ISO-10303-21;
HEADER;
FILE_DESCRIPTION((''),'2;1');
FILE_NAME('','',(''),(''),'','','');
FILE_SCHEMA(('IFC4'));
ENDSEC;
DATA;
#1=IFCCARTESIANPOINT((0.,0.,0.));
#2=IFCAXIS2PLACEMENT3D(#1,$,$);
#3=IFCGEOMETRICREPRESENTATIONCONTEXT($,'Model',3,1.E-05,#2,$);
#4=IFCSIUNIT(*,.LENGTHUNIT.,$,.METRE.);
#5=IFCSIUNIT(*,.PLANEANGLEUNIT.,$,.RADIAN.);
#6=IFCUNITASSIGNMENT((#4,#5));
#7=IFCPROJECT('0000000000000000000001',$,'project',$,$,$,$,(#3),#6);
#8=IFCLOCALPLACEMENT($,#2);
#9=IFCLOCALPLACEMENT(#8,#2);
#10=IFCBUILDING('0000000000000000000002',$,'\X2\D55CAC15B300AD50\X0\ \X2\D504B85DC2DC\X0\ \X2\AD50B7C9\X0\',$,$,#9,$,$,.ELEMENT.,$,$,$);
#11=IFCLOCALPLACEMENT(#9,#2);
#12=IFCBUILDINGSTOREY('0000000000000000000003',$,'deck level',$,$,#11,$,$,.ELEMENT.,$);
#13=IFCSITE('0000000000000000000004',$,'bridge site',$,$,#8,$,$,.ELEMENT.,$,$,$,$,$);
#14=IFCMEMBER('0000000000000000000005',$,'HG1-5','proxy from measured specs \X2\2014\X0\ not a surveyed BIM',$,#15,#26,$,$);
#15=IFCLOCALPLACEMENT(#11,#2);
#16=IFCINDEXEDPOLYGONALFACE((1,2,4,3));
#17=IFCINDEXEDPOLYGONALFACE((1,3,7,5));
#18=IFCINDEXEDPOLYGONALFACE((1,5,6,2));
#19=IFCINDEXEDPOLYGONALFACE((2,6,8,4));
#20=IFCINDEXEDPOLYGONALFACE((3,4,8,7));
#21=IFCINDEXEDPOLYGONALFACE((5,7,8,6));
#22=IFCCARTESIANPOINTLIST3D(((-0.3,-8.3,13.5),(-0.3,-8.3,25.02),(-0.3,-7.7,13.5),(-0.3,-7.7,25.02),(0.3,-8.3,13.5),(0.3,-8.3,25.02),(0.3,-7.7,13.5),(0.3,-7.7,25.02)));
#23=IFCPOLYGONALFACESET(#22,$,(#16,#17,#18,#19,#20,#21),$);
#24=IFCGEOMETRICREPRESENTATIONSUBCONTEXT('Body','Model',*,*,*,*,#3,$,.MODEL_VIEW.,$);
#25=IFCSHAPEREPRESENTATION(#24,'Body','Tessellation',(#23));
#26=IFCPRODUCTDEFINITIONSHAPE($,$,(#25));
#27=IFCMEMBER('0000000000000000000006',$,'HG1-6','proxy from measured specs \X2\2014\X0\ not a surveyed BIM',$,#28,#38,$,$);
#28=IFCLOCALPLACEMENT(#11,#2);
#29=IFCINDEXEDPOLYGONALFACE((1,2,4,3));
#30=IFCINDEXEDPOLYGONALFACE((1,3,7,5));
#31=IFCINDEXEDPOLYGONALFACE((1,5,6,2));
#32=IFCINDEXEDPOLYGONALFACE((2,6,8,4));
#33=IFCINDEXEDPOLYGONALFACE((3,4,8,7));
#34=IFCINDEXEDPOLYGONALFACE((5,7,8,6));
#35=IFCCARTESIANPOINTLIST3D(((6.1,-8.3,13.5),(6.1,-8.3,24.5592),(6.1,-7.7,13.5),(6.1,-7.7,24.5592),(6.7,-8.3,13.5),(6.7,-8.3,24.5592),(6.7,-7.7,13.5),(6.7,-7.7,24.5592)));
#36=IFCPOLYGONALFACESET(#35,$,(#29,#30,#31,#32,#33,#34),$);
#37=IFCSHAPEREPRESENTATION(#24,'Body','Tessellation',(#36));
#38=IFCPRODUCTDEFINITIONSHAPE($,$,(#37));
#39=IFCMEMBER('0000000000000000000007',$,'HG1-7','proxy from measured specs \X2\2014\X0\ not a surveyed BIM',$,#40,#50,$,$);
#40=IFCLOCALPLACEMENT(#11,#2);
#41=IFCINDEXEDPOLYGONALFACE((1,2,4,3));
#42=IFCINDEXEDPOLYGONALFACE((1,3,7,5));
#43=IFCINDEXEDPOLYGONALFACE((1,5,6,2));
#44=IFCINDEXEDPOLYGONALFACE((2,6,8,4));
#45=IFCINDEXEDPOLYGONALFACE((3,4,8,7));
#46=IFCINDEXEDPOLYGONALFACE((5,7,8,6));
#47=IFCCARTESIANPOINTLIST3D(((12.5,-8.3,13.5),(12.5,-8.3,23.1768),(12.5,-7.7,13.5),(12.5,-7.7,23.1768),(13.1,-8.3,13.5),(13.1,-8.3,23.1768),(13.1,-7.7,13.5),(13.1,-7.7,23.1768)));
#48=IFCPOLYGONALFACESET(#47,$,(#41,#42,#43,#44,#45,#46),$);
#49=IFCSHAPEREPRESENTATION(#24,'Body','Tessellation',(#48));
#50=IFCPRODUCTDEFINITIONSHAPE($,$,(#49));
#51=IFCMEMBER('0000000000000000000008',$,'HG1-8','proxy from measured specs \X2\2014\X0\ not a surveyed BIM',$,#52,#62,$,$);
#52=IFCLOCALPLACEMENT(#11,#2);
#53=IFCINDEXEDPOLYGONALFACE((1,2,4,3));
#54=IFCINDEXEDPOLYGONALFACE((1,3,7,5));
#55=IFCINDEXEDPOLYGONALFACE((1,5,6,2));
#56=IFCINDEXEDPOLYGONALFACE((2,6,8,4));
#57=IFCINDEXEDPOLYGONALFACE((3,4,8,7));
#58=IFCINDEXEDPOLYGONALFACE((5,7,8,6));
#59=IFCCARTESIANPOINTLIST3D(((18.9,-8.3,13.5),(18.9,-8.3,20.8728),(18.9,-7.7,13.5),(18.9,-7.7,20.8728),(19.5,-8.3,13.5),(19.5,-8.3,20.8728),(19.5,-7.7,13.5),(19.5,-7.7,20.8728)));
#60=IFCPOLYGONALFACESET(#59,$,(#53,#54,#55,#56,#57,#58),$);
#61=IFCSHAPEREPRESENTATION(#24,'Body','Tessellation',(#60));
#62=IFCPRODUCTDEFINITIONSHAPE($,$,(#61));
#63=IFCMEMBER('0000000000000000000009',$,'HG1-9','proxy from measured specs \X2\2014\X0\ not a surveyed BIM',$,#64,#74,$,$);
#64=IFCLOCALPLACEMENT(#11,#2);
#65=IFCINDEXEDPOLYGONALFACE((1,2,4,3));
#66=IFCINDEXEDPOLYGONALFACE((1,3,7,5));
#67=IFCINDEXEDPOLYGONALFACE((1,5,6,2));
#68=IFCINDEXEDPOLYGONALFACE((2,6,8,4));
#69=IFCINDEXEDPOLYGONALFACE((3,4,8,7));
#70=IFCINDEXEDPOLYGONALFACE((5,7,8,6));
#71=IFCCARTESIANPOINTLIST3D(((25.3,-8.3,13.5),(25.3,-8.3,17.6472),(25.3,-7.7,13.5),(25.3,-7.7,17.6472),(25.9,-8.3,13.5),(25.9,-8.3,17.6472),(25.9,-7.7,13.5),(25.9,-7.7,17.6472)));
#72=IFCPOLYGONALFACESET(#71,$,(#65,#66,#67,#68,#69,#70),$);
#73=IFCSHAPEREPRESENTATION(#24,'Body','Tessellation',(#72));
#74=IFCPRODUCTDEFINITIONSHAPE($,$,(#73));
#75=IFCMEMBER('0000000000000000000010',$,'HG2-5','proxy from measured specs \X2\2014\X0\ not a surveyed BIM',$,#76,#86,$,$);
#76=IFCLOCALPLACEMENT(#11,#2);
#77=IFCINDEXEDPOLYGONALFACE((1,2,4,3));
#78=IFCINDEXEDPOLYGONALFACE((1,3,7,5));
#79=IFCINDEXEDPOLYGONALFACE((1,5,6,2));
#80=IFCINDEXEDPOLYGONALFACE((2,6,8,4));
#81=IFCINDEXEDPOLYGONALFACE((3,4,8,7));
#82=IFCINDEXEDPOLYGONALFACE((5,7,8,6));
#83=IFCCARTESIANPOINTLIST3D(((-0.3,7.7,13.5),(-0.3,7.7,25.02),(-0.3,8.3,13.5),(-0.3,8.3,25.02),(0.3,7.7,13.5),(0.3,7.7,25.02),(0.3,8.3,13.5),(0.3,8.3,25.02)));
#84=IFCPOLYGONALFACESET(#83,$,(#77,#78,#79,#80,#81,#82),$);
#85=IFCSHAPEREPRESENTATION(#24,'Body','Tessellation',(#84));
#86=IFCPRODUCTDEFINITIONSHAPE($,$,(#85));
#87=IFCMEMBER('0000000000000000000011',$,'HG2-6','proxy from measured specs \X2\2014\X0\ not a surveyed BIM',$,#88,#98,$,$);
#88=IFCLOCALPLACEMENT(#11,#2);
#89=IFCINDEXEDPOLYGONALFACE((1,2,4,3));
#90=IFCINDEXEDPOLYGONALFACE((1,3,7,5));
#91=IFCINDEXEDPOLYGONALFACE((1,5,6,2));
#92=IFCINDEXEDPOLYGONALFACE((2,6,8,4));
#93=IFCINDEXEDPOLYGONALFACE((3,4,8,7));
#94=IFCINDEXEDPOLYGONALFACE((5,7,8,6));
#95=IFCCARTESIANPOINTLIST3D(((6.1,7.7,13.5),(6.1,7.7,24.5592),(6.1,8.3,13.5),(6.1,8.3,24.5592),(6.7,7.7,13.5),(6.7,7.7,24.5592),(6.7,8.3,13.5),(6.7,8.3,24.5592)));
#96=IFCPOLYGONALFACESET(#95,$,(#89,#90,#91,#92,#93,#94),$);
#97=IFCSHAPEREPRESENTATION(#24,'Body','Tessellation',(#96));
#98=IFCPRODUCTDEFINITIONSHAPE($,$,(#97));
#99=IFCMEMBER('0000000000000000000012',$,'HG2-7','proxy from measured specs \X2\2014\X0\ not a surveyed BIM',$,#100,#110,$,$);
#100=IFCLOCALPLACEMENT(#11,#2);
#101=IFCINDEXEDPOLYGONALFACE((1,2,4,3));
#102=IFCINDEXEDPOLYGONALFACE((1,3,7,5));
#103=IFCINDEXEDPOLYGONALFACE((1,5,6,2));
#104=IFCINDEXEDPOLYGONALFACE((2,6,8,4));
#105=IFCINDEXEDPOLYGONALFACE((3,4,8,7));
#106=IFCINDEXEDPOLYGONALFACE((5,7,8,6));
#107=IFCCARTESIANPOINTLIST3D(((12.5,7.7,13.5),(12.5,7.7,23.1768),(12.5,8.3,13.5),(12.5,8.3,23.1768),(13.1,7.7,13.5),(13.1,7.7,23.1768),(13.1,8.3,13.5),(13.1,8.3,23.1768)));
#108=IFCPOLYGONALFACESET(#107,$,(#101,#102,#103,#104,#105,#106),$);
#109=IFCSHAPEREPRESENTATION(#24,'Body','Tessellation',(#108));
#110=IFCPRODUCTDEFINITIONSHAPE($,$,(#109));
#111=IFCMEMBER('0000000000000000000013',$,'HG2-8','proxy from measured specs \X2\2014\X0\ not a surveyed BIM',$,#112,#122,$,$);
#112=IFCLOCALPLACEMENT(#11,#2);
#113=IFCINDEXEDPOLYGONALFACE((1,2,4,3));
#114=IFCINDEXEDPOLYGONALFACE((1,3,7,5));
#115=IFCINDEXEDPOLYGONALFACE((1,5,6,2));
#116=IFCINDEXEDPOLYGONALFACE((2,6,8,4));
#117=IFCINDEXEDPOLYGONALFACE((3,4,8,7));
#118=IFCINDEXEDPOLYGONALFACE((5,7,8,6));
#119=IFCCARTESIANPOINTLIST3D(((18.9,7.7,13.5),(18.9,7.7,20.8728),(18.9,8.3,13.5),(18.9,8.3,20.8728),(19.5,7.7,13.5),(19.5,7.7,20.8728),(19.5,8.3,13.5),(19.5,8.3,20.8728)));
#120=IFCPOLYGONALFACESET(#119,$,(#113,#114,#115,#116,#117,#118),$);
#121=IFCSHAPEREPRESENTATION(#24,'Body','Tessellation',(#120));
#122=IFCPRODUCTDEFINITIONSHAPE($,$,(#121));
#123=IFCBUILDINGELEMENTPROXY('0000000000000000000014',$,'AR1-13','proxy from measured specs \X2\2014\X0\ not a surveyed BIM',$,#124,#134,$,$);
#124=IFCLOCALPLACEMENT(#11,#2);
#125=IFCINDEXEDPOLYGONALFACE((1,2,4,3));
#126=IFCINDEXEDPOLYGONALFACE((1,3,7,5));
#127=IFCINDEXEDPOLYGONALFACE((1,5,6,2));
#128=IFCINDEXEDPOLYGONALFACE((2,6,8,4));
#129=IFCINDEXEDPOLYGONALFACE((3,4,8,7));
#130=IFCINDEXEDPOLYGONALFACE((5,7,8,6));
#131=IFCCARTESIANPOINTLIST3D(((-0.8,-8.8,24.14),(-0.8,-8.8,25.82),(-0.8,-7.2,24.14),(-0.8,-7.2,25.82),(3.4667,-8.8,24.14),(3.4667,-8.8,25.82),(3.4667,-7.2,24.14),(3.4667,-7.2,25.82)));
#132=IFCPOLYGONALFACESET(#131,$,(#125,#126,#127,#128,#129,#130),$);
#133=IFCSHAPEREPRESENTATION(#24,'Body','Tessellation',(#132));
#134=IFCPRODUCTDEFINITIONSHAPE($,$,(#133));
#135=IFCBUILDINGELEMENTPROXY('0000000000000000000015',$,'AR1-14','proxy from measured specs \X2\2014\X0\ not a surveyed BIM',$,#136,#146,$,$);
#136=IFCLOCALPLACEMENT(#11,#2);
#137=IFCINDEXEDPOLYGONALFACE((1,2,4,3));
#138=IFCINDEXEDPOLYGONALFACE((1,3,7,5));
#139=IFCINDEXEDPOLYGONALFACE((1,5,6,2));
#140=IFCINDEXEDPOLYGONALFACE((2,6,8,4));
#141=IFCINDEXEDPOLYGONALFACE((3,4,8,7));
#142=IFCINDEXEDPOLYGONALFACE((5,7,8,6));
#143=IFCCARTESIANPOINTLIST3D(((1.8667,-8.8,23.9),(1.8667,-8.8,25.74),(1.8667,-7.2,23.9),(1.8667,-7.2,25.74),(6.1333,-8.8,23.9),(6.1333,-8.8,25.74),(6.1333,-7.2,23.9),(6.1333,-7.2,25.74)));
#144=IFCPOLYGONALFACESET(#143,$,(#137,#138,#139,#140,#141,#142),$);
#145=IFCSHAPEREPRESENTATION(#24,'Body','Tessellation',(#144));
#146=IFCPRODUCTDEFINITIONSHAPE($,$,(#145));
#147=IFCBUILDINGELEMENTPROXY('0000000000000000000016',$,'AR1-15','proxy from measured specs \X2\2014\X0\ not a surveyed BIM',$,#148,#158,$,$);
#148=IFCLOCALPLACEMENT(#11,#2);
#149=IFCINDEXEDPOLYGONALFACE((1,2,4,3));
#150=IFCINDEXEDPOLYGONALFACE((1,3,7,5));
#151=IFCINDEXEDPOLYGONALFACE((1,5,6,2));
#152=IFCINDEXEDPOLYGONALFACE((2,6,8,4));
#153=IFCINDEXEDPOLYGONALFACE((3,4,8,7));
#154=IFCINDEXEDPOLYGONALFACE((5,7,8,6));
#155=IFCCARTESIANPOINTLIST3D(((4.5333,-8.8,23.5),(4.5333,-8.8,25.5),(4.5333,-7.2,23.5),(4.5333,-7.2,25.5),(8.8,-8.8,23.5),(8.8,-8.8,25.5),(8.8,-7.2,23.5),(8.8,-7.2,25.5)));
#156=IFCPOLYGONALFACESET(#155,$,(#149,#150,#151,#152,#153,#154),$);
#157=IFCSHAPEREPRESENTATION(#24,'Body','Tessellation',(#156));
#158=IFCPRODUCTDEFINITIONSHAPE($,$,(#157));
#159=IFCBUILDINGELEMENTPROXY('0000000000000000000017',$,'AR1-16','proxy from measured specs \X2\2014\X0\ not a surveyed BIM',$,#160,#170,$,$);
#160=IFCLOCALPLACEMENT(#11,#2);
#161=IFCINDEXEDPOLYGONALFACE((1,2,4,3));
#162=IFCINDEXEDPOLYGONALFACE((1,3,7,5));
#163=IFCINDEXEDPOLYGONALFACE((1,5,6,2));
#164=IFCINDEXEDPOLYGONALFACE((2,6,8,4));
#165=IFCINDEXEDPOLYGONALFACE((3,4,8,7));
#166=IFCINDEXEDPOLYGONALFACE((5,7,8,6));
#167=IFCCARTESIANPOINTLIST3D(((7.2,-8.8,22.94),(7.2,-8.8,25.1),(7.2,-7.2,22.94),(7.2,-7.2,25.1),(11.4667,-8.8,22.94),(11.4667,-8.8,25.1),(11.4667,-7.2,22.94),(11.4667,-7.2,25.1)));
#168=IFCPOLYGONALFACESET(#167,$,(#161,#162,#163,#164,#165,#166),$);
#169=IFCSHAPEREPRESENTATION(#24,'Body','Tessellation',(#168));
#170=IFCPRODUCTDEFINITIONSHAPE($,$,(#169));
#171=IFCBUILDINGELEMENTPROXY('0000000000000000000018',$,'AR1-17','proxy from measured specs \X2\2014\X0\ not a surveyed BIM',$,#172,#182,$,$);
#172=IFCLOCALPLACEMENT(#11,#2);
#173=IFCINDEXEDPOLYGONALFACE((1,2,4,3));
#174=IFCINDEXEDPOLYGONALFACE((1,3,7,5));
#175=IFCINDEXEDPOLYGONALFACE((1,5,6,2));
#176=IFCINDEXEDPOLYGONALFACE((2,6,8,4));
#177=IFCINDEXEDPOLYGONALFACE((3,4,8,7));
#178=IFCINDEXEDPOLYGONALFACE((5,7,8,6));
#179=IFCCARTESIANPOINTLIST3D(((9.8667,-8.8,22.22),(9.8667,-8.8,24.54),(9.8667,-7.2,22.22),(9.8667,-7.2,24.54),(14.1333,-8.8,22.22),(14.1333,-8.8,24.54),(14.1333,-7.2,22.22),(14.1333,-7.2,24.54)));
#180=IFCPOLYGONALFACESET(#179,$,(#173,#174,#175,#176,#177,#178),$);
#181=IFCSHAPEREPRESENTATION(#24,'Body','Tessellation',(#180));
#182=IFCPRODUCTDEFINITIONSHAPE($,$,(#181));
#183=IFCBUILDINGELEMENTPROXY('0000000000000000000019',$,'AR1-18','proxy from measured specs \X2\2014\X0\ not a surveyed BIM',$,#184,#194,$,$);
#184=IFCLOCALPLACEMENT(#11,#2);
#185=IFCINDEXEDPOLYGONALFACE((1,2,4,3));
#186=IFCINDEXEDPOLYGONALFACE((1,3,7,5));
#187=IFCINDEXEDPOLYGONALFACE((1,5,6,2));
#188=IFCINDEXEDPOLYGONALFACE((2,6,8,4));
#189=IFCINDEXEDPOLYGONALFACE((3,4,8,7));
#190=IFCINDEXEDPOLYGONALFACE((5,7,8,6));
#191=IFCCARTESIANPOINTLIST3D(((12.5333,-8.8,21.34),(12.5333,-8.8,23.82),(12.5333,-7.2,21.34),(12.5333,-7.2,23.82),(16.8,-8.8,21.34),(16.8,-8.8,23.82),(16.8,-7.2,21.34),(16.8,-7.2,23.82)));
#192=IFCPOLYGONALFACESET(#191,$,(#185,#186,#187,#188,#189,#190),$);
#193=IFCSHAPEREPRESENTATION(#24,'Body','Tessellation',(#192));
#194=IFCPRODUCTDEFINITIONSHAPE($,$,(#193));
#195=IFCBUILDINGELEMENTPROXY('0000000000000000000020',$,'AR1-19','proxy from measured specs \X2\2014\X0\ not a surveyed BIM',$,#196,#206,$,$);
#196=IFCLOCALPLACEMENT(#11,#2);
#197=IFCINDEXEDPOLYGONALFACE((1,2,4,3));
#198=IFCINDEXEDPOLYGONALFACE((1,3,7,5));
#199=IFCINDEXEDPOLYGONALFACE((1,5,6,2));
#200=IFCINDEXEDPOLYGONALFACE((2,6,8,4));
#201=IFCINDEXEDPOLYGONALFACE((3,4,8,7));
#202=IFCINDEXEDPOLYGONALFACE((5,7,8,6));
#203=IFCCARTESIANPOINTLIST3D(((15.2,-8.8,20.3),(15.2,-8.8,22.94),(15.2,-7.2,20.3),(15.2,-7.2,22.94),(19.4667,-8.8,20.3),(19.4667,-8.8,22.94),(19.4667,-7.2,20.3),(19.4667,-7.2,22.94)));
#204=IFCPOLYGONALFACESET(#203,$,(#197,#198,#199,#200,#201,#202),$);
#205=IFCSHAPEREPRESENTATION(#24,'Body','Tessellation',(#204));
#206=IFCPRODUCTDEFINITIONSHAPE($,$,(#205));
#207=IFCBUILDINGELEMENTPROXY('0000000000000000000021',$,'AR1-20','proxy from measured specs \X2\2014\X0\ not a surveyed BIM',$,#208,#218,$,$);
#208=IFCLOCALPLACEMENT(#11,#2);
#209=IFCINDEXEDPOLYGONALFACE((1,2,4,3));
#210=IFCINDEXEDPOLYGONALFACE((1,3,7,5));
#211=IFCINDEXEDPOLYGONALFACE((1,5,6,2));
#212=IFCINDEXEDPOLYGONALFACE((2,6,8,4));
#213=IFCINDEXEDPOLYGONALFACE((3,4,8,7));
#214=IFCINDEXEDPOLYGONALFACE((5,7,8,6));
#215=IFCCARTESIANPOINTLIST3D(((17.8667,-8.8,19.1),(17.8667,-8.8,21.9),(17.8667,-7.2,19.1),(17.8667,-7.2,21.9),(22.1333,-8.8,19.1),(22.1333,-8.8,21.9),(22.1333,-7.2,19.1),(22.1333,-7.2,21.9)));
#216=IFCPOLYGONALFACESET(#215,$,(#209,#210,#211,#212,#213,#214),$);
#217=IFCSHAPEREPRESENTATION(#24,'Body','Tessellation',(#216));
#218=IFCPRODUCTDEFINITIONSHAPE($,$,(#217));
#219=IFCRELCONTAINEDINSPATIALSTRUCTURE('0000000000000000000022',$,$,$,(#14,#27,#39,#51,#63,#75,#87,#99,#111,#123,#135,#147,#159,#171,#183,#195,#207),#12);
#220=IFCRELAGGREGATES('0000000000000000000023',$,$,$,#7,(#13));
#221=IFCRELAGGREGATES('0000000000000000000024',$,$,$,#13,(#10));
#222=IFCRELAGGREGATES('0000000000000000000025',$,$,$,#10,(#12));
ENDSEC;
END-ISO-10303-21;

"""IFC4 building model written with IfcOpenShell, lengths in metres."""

from ifc_helpers import new_model, si_unit, frame, origin, origin_2d, place, context, subcontext, project, spatial, rectangle, extrude, element, save


model = new_model("IFC4")

# Units and contexts
model_context = context("Model", 3, precision=1e-05, world=origin())
body_context = subcontext(model_context, "Body", "Model", "MODEL_VIEW")
ifc_project = project(units=[si_unit("LENGTHUNIT", "METRE"), si_unit("PLANEANGLEUNIT", "RADIAN")], contexts=[model_context])

# Site, building, storey
site_placement = place(None, origin())
site = spatial("IfcSite", under=ifc_project, at=site_placement, Name="bridge site", CompositionType="ELEMENT")
building_placement = place(site_placement, origin())
building = spatial("IfcBuilding", under=site, at=building_placement, Name="한강대교 프록시 교량", CompositionType="ELEMENT")
storey_placement = place(building_placement, origin())
storey = spatial("IfcBuildingStorey", under=building, at=storey_placement, Name="deck level", CompositionType="ELEMENT")

# Members
member_1_placement = place(storey_placement, frame((0.0, -8.0, 13.5)))
element("IfcMember", 1, at=member_1_placement, inside=storey, Name="HG1-5", Description="proxy from measured specs — not a surveyed BIM", context=body_context, shape_type="SweptSolid", body=[
    extrude(rectangle(XDim=0.6, YDim=0.6, at=origin_2d()), origin(), (0.0, 0.0, 1.0), 11.52),
])
member_2_placement = place(storey_placement, frame((6.4, -8.0, 13.5)))
element("IfcMember", 2, at=member_2_placement, inside=storey, Name="HG1-6", Description="proxy from measured specs — not a surveyed BIM", context=body_context, shape_type="SweptSolid", body=[
    extrude(rectangle(XDim=0.6, YDim=0.6, at=origin_2d()), origin(), (0.0, 0.0, 1.0), 11.0592),
])
member_3_placement = place(storey_placement, frame((12.8, -8.0, 13.5)))
element("IfcMember", 3, at=member_3_placement, inside=storey, Name="HG1-7", Description="proxy from measured specs — not a surveyed BIM", context=body_context, shape_type="SweptSolid", body=[
    extrude(rectangle(XDim=0.6, YDim=0.6, at=origin_2d()), origin(), (0.0, 0.0, 1.0), 9.6768),
])
member_4_placement = place(storey_placement, frame((19.2, -8.0, 13.5)))
element("IfcMember", 4, at=member_4_placement, inside=storey, Name="HG1-8", Description="proxy from measured specs — not a surveyed BIM", context=body_context, shape_type="SweptSolid", body=[
    extrude(rectangle(XDim=0.6, YDim=0.6, at=origin_2d()), origin(), (0.0, 0.0, 1.0), 7.3728),
])
member_5_placement = place(storey_placement, frame((25.6, -8.0, 13.5)))
element("IfcMember", 5, at=member_5_placement, inside=storey, Name="HG1-9", Description="proxy from measured specs — not a surveyed BIM", context=body_context, shape_type="SweptSolid", body=[
    extrude(rectangle(XDim=0.6, YDim=0.6, at=origin_2d()), origin(), (0.0, 0.0, 1.0), 4.1472),
])
member_6_placement = place(storey_placement, frame((0.0, 8.0, 13.5)))
element("IfcMember", 6, at=member_6_placement, inside=storey, Name="HG2-5", Description="proxy from measured specs — not a surveyed BIM", context=body_context, shape_type="SweptSolid", body=[
    extrude(rectangle(XDim=0.6, YDim=0.6, at=origin_2d()), origin(), (0.0, 0.0, 1.0), 11.52),
])
member_7_placement = place(storey_placement, frame((6.4, 8.0, 13.5)))
element("IfcMember", 7, at=member_7_placement, inside=storey, Name="HG2-6", Description="proxy from measured specs — not a surveyed BIM", context=body_context, shape_type="SweptSolid", body=[
    extrude(rectangle(XDim=0.6, YDim=0.6, at=origin_2d()), origin(), (0.0, 0.0, 1.0), 11.0592),
])
member_8_placement = place(storey_placement, frame((12.8, 8.0, 13.5)))
element("IfcMember", 8, at=member_8_placement, inside=storey, Name="HG2-7", Description="proxy from measured specs — not a surveyed BIM", context=body_context, shape_type="SweptSolid", body=[
    extrude(rectangle(XDim=0.6, YDim=0.6, at=origin_2d()), origin(), (0.0, 0.0, 1.0), 9.6768),
])
member_9_placement = place(storey_placement, frame((19.2, 8.0, 13.5)))
element("IfcMember", 9, at=member_9_placement, inside=storey, Name="HG2-8", Description="proxy from measured specs — not a surveyed BIM", context=body_context, shape_type="SweptSolid", body=[
    extrude(rectangle(XDim=0.6, YDim=0.6, at=origin_2d()), origin(), (0.0, 0.0, 1.0), 7.3728),
])

# Building element proxies
proxy_1_placement = place(storey_placement, frame((1.3333, -8.0, 24.14)))
element("IfcBuildingElementProxy", 10, at=proxy_1_placement, inside=storey, Name="AR1-13", Description="proxy from measured specs — not a surveyed BIM", context=body_context, shape_type="SweptSolid", body=[
    extrude(rectangle(XDim=4.2667, YDim=1.6, at=origin_2d()), origin(), (0.0, 0.0, 1.0), 1.68),
])
proxy_2_placement = place(storey_placement, frame((4.0, -8.0, 23.9)))
element("IfcBuildingElementProxy", 11, at=proxy_2_placement, inside=storey, Name="AR1-14", Description="proxy from measured specs — not a surveyed BIM", context=body_context, shape_type="SweptSolid", body=[
    extrude(rectangle(XDim=4.2667, YDim=1.6, at=origin_2d()), origin(), (0.0, 0.0, 1.0), 1.84),
])
proxy_3_placement = place(storey_placement, frame((6.6667, -8.0, 23.5)))
element("IfcBuildingElementProxy", 12, at=proxy_3_placement, inside=storey, Name="AR1-15", Description="proxy from measured specs — not a surveyed BIM", context=body_context, shape_type="SweptSolid", body=[
    extrude(rectangle(XDim=4.2667, YDim=1.6, at=origin_2d()), origin(), (0.0, 0.0, 1.0), 2.0),
])
proxy_4_placement = place(storey_placement, frame((9.3333, -8.0, 22.94)))
element("IfcBuildingElementProxy", 13, at=proxy_4_placement, inside=storey, Name="AR1-16", Description="proxy from measured specs — not a surveyed BIM", context=body_context, shape_type="SweptSolid", body=[
    extrude(rectangle(XDim=4.2667, YDim=1.6, at=origin_2d()), origin(), (0.0, 0.0, 1.0), 2.16),
])
proxy_5_placement = place(storey_placement, frame((12.0, -8.0, 22.22)))
element("IfcBuildingElementProxy", 14, at=proxy_5_placement, inside=storey, Name="AR1-17", Description="proxy from measured specs — not a surveyed BIM", context=body_context, shape_type="SweptSolid", body=[
    extrude(rectangle(XDim=4.2667, YDim=1.6, at=origin_2d()), origin(), (0.0, 0.0, 1.0), 2.32),
])
proxy_6_placement = place(storey_placement, frame((14.6667, -8.0, 21.34)))
element("IfcBuildingElementProxy", 15, at=proxy_6_placement, inside=storey, Name="AR1-18", Description="proxy from measured specs — not a surveyed BIM", context=body_context, shape_type="SweptSolid", body=[
    extrude(rectangle(XDim=4.2667, YDim=1.6, at=origin_2d()), origin(), (0.0, 0.0, 1.0), 2.48),
])
proxy_7_placement = place(storey_placement, frame((17.3333, -8.0, 20.3)))
element("IfcBuildingElementProxy", 16, at=proxy_7_placement, inside=storey, Name="AR1-19", Description="proxy from measured specs — not a surveyed BIM", context=body_context, shape_type="SweptSolid", body=[
    extrude(rectangle(XDim=4.2667, YDim=1.6, at=origin_2d()), origin(), (0.0, 0.0, 1.0), 2.64),
])
proxy_8_placement = place(storey_placement, frame((20.0, -8.0, 19.1)))
element("IfcBuildingElementProxy", 17, at=proxy_8_placement, inside=storey, Name="AR1-20", Description="proxy from measured specs — not a surveyed BIM", context=body_context, shape_type="SweptSolid", body=[
    extrude(rectangle(XDim=4.2667, YDim=1.6, at=origin_2d()), origin(), (0.0, 0.0, 1.0), 2.8),
])

save(model, "model.ifc")
